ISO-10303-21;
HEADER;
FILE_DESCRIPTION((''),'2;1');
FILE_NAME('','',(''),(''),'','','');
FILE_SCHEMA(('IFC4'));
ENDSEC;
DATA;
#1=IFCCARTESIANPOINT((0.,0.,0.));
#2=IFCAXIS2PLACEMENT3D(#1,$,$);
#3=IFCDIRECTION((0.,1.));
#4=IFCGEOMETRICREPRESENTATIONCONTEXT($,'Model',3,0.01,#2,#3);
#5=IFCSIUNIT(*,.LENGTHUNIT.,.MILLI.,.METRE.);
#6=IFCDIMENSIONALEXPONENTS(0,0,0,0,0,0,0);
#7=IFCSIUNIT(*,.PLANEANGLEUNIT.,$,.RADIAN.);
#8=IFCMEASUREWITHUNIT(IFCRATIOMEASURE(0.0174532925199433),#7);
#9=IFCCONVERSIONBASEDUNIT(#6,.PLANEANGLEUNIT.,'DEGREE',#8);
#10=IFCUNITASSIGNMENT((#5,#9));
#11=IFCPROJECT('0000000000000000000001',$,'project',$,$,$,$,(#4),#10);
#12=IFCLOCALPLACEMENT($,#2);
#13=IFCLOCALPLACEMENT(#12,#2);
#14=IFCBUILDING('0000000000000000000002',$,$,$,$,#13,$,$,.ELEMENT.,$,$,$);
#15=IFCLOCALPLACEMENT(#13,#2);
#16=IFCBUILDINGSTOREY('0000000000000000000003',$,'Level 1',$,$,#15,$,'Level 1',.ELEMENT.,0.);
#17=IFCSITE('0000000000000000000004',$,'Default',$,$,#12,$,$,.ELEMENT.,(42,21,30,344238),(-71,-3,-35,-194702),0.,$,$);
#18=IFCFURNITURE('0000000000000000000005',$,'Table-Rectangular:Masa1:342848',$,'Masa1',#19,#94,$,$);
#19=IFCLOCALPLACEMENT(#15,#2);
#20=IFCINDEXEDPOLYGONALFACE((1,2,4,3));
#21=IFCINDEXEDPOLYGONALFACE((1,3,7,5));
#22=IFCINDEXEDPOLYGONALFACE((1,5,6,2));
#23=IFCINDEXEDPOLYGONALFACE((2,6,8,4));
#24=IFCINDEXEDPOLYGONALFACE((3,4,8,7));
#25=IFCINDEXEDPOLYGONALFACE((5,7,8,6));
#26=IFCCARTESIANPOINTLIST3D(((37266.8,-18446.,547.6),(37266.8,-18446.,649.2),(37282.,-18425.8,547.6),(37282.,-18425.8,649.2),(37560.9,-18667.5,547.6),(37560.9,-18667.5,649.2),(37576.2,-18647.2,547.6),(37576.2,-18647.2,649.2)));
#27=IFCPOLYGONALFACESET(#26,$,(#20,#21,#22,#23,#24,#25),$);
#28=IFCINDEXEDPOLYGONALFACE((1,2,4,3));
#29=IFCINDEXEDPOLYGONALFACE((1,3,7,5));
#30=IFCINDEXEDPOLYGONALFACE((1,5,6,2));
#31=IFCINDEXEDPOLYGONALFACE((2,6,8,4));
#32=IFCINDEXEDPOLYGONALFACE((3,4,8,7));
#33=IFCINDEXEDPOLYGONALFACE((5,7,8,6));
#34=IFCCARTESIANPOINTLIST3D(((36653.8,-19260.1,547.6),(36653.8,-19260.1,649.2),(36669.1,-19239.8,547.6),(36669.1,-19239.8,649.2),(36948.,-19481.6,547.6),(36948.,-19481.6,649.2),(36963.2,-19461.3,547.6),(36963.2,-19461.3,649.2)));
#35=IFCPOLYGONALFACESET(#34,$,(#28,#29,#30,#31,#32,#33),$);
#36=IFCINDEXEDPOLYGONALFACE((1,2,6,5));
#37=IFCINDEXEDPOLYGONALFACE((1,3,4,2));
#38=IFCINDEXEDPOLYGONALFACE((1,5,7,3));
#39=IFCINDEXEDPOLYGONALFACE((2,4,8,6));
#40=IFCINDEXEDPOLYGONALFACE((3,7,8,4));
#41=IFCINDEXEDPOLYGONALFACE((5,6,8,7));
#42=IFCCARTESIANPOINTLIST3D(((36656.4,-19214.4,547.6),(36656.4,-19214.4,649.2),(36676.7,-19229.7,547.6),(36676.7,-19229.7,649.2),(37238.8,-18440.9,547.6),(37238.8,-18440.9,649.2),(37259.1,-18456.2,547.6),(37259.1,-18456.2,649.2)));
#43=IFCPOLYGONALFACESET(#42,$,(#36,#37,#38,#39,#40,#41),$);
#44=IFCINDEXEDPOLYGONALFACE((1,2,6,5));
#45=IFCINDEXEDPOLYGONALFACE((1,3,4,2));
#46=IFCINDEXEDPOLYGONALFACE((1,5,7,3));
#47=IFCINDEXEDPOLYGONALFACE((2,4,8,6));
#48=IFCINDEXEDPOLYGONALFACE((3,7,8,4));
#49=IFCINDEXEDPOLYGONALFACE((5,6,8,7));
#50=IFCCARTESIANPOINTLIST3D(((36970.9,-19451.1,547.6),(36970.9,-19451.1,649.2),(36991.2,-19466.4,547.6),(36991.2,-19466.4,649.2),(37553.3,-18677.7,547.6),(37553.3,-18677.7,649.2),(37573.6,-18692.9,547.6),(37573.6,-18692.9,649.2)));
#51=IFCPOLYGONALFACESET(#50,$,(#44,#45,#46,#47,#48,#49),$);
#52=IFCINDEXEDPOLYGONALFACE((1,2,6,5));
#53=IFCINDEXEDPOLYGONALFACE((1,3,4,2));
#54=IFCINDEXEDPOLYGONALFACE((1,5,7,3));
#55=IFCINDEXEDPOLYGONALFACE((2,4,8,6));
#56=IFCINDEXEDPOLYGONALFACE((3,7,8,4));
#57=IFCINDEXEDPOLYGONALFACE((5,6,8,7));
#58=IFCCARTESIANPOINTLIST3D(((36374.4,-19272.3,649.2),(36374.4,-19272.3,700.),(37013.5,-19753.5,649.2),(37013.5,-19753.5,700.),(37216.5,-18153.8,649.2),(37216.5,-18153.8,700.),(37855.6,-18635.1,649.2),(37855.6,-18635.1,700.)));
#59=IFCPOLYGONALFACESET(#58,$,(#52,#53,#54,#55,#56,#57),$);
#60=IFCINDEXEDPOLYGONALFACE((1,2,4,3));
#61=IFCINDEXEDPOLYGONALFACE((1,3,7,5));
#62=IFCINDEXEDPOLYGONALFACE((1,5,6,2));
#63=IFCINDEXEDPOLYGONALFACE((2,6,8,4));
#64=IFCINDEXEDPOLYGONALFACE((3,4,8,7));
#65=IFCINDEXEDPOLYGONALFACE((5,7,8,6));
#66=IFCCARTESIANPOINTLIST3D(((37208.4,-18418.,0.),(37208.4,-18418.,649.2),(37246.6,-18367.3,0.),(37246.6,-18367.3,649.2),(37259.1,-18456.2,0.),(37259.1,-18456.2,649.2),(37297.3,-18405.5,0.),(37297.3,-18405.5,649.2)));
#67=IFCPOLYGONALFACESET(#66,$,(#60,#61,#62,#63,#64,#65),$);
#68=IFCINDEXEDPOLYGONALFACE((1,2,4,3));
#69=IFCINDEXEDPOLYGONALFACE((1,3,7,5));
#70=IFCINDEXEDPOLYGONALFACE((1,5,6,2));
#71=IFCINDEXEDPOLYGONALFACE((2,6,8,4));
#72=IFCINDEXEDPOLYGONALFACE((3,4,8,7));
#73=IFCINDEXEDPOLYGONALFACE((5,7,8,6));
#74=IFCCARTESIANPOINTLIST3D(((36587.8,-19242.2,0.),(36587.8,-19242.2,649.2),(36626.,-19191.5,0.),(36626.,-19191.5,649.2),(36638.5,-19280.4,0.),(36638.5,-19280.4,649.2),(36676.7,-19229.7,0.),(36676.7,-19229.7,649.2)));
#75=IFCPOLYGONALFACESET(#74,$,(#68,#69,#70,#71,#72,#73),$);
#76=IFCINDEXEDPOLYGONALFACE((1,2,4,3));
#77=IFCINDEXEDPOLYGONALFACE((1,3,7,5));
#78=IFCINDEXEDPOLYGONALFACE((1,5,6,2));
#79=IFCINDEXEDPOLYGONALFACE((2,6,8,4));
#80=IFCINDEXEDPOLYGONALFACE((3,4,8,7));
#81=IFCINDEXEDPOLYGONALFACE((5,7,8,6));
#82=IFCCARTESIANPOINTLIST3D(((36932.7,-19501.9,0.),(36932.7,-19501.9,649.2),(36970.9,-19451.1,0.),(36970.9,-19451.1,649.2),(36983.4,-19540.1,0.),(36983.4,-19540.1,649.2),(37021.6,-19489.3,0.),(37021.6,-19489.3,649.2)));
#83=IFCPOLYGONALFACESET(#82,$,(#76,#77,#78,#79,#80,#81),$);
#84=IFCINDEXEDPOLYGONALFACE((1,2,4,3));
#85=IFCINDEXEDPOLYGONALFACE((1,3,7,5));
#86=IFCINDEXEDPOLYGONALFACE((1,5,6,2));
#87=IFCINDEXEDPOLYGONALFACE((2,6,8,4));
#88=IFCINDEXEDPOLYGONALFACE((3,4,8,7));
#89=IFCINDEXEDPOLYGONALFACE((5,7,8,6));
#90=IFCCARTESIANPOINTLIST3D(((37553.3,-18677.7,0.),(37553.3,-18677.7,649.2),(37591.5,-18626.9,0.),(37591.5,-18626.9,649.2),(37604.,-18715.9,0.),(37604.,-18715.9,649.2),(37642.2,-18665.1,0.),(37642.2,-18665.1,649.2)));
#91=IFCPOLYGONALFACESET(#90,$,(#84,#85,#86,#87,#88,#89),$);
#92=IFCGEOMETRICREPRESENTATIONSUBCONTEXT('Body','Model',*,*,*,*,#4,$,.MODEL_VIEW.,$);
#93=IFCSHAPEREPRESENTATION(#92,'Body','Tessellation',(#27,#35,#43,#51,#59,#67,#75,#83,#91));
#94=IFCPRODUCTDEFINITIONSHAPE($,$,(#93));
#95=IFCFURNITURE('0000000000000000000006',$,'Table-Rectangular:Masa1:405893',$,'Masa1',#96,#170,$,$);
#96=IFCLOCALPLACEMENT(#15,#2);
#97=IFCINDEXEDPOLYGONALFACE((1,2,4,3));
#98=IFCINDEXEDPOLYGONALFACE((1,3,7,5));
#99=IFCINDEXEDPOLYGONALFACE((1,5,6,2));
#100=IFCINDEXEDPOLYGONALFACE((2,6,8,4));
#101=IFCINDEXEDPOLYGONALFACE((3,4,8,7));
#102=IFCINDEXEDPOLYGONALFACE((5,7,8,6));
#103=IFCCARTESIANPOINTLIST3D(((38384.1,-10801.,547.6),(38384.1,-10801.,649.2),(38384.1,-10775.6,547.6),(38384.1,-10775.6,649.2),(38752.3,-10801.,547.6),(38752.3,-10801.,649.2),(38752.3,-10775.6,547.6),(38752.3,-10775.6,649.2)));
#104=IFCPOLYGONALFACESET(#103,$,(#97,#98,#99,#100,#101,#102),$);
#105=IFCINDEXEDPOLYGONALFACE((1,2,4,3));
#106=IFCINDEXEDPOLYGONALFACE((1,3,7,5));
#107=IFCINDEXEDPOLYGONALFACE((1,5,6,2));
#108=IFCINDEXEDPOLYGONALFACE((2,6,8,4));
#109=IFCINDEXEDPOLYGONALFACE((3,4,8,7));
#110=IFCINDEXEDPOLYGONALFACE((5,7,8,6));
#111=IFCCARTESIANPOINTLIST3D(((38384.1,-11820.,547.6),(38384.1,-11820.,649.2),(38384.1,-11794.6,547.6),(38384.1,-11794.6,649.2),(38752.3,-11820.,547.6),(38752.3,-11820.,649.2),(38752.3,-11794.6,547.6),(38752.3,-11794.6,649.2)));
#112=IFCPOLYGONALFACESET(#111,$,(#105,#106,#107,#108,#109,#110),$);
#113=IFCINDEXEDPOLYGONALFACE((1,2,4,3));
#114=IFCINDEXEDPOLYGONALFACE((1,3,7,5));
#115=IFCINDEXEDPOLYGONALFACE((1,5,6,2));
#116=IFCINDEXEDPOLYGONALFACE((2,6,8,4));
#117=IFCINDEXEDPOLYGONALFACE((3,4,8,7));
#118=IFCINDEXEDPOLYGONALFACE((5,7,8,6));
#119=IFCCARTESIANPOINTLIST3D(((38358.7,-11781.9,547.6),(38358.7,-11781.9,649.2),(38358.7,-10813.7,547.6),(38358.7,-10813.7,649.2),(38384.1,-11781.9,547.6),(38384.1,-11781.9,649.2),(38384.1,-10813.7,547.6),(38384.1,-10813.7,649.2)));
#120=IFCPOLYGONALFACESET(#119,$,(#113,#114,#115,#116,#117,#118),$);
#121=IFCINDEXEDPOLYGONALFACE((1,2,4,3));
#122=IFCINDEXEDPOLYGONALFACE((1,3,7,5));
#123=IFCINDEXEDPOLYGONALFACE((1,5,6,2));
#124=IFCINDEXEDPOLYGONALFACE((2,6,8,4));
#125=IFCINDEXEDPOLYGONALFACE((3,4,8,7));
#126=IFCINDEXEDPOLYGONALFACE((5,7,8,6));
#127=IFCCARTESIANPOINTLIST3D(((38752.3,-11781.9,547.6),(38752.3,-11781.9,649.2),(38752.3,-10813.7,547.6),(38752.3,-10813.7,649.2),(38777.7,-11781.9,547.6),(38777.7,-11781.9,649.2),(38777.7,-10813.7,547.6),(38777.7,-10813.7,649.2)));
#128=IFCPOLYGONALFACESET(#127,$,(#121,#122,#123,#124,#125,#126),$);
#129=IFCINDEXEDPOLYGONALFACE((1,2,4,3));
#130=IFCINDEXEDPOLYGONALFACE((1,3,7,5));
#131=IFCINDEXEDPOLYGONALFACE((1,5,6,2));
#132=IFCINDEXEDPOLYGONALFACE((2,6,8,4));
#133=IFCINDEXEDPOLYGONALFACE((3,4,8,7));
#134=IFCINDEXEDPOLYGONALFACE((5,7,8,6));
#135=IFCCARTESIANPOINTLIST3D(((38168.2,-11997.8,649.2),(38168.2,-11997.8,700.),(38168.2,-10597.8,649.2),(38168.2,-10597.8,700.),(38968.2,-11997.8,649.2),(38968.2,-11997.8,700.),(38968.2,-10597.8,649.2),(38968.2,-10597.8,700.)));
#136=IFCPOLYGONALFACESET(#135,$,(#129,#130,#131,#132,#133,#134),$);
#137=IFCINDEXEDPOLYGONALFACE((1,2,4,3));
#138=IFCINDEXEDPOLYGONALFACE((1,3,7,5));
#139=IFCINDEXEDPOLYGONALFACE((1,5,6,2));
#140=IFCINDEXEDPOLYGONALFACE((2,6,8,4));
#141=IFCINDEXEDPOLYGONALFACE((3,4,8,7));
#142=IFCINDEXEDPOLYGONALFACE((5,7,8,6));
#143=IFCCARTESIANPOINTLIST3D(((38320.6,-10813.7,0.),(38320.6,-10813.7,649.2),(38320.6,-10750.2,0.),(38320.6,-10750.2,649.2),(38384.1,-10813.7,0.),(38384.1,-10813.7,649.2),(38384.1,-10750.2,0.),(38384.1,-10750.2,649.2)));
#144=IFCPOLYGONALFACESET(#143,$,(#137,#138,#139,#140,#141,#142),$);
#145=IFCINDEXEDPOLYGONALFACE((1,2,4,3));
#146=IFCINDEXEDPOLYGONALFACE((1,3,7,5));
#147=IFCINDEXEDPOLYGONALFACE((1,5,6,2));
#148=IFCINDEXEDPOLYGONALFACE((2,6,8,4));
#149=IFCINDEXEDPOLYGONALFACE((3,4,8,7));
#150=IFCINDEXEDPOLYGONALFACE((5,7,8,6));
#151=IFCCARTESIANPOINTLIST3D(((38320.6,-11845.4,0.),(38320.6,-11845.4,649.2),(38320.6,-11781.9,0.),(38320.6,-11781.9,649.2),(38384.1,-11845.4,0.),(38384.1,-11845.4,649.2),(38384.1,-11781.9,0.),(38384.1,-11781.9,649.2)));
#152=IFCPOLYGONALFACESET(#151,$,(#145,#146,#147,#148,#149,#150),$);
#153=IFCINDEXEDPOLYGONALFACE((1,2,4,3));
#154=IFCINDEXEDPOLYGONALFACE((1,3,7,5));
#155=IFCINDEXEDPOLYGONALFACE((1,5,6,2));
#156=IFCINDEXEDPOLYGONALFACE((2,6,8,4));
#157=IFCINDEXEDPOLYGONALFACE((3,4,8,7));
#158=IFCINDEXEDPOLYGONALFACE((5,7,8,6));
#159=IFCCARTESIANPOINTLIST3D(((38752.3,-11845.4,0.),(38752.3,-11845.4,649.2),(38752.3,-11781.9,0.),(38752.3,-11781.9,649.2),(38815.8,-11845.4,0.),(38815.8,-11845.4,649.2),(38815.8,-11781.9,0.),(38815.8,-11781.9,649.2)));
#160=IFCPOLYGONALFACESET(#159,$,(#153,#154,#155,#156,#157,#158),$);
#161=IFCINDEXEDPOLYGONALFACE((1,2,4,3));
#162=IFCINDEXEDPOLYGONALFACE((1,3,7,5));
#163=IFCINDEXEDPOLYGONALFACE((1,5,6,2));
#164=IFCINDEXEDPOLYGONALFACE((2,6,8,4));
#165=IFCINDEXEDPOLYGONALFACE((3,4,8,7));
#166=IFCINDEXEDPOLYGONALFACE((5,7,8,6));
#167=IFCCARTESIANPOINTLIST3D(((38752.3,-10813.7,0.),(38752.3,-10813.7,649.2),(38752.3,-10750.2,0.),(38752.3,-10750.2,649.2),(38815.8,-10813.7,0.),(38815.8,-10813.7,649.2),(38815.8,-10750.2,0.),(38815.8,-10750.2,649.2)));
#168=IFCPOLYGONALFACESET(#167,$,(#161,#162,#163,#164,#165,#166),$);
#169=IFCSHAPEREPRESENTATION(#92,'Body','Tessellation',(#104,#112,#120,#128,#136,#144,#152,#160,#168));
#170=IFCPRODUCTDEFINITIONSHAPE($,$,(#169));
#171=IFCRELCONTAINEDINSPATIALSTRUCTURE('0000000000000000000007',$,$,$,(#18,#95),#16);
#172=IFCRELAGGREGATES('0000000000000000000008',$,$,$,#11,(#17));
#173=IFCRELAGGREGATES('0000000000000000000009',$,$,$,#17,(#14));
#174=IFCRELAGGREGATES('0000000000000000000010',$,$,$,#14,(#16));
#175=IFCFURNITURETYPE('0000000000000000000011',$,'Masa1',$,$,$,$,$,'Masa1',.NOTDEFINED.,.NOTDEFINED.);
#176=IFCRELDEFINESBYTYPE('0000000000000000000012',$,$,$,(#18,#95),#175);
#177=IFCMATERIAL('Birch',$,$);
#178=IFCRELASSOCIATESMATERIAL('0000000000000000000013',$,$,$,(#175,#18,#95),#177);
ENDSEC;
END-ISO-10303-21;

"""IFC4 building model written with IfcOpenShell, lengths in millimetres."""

from ifc_helpers import new_model, entity, si_unit, converted_unit, direction, frame, frame_2d, origin, origin_2d_with_axis, place, context, subcontext, project, spatial, rectangle, extrude, source, transform, mapped, material, type_object, type_shapes, element, save


model = new_model("IFC4")

# Units and contexts
model_context = context("Model", 3, precision=0.01, world=origin(), true_north=direction((0.0, 1.0)))
body_context = subcontext(model_context, "Body", "Model", "MODEL_VIEW")
ifc_project = project(units=[si_unit("LENGTHUNIT", "METRE", prefix="MILLI"), converted_unit("PLANEANGLEUNIT", "DEGREE", entity("IfcRatioMeasure", 0.0174532925199433), si_unit("PLANEANGLEUNIT", "RADIAN"), dimensions=[0, 0, 0, 0, 0, 0, 0])], contexts=[model_context])

# Site, building, storey
site_placement = place(None, origin())
site = spatial("IfcSite", under=ifc_project, at=site_placement, Name="Default", CompositionType="ELEMENT", RefLatitude=(42, 21, 30, 344238), RefLongitude=(-71, -3, -35, -194702), RefElevation=0.0)
building_placement = place(site_placement, origin())
building = spatial("IfcBuilding", under=site, at=building_placement, CompositionType="ELEMENT")
storey_placement = place(building_placement, origin())
storey = spatial("IfcBuildingStorey", under=building, at=storey_placement, Name="Level 1", LongName="Level 1", CompositionType="ELEMENT", Elevation=0.0)

# Furniture
ifc_material_1 = material(Name="Birch")
furniture_type_1 = type_object("IfcFurnitureType", Name="Masa1", ElementType="Masa1", AssemblyPlace="NOTDEFINED", PredefinedType="NOTDEFINED", material=ifc_material_1)
shared_shape_1 = source(origin(), body_context, "Body", "SweptSolid", [
    extrude(rectangle(XDim=25.4, YDim=368.2, at=origin_2d_with_axis()), frame((509.5, 0.0, 547.6)), (0.0, 0.0, 1.0), 101.6),
    extrude(rectangle(XDim=368.2, YDim=25.4, at=origin_2d_with_axis()), frame((-509.5, 0.0, 547.6), z_axis=(0.0, 0.0, 1.0), x_axis=(0.0, 1.0, 0.0)), (0.0, 0.0, 1.0), 101.6),
    extrude(rectangle(XDim=968.2, YDim=25.4, at=frame_2d((0.0, 0.0), x_axis=(1.0, 0.0))), frame((0.0, 196.8, 547.6), z_axis=(0.0, 0.0, 1.0), x_axis=(-1.0, 0.0, 0.0)), (0.0, 0.0, 1.0), 101.6),
    extrude(rectangle(XDim=25.4, YDim=968.2, at=origin_2d_with_axis()), frame((0.0, -196.8, 547.6), z_axis=(0.0, 0.0, 1.0), x_axis=(0.0, 1.0, 0.0)), (0.0, 0.0, 1.0), 101.6),
    extrude(rectangle(XDim=1400.0, YDim=800.0, at=origin_2d_with_axis()), frame((0.0, 0.0, 649.2), z_axis=(0.0, 0.0, 1.0), x_axis=(-1.0, 0.0, 0.0)), (0.0, 0.0, 1.0), 50.8),
    extrude(rectangle(XDim=63.5, YDim=63.5, at=origin_2d_with_axis()), frame((515.9, 215.9, 0.0), z_axis=(0.0, 0.0, 1.0), x_axis=(0.0, -1.0, 0.0)), (0.0, 0.0, 1.0), 649.2),
    extrude(rectangle(XDim=63.5, YDim=63.5, at=origin_2d_with_axis()), frame((-515.9, 215.9, 0.0), z_axis=(0.0, 0.0, 1.0), x_axis=(-1.0, 0.0, 0.0)), (0.0, 0.0, 1.0), 649.2),
    extrude(rectangle(XDim=63.5, YDim=63.5, at=origin_2d_with_axis()), frame((-515.9, -215.9, 0.0), z_axis=(0.0, 0.0, 1.0), x_axis=(0.0, 1.0, 0.0)), (0.0, 0.0, 1.0), 649.2),
    extrude(rectangle(XDim=63.5, YDim=63.5, at=frame_2d((0.0, 0.0), x_axis=(1.0, 0.0))), frame((515.9, -215.9, 0.0)), (0.0, 0.0, 1.0), 649.2),
])
type_shapes(furniture_type_1, [shared_shape_1])
for number, where, z_axis, x_axis, name in (
    (1, (37115.0, -18953.7, 0.0), (0.0, 0.0, 1.0), (0.601507, 0.798867, 0.0), "Table-Rectangular:Masa1:342848"),
    (2, (38568.2, -11297.8, 0.0), (0.0, 0.0, 1.0), (0.0, 1.0, 0.0), "Table-Rectangular:Masa1:405893"),
):
    element("IfcFurniture", number, at=place(storey_placement, frame(where, z_axis=z_axis, x_axis=x_axis)), inside=storey, type_object=furniture_type_1, material=ifc_material_1, Name=name, ObjectType="Masa1", context=body_context, shape_type="MappedRepresentation", body=[
        mapped(shared_shape_1, transform((0.0, 0.0, 0.0), scale=1.0)),
    ])

save(model, "model.ifc")
